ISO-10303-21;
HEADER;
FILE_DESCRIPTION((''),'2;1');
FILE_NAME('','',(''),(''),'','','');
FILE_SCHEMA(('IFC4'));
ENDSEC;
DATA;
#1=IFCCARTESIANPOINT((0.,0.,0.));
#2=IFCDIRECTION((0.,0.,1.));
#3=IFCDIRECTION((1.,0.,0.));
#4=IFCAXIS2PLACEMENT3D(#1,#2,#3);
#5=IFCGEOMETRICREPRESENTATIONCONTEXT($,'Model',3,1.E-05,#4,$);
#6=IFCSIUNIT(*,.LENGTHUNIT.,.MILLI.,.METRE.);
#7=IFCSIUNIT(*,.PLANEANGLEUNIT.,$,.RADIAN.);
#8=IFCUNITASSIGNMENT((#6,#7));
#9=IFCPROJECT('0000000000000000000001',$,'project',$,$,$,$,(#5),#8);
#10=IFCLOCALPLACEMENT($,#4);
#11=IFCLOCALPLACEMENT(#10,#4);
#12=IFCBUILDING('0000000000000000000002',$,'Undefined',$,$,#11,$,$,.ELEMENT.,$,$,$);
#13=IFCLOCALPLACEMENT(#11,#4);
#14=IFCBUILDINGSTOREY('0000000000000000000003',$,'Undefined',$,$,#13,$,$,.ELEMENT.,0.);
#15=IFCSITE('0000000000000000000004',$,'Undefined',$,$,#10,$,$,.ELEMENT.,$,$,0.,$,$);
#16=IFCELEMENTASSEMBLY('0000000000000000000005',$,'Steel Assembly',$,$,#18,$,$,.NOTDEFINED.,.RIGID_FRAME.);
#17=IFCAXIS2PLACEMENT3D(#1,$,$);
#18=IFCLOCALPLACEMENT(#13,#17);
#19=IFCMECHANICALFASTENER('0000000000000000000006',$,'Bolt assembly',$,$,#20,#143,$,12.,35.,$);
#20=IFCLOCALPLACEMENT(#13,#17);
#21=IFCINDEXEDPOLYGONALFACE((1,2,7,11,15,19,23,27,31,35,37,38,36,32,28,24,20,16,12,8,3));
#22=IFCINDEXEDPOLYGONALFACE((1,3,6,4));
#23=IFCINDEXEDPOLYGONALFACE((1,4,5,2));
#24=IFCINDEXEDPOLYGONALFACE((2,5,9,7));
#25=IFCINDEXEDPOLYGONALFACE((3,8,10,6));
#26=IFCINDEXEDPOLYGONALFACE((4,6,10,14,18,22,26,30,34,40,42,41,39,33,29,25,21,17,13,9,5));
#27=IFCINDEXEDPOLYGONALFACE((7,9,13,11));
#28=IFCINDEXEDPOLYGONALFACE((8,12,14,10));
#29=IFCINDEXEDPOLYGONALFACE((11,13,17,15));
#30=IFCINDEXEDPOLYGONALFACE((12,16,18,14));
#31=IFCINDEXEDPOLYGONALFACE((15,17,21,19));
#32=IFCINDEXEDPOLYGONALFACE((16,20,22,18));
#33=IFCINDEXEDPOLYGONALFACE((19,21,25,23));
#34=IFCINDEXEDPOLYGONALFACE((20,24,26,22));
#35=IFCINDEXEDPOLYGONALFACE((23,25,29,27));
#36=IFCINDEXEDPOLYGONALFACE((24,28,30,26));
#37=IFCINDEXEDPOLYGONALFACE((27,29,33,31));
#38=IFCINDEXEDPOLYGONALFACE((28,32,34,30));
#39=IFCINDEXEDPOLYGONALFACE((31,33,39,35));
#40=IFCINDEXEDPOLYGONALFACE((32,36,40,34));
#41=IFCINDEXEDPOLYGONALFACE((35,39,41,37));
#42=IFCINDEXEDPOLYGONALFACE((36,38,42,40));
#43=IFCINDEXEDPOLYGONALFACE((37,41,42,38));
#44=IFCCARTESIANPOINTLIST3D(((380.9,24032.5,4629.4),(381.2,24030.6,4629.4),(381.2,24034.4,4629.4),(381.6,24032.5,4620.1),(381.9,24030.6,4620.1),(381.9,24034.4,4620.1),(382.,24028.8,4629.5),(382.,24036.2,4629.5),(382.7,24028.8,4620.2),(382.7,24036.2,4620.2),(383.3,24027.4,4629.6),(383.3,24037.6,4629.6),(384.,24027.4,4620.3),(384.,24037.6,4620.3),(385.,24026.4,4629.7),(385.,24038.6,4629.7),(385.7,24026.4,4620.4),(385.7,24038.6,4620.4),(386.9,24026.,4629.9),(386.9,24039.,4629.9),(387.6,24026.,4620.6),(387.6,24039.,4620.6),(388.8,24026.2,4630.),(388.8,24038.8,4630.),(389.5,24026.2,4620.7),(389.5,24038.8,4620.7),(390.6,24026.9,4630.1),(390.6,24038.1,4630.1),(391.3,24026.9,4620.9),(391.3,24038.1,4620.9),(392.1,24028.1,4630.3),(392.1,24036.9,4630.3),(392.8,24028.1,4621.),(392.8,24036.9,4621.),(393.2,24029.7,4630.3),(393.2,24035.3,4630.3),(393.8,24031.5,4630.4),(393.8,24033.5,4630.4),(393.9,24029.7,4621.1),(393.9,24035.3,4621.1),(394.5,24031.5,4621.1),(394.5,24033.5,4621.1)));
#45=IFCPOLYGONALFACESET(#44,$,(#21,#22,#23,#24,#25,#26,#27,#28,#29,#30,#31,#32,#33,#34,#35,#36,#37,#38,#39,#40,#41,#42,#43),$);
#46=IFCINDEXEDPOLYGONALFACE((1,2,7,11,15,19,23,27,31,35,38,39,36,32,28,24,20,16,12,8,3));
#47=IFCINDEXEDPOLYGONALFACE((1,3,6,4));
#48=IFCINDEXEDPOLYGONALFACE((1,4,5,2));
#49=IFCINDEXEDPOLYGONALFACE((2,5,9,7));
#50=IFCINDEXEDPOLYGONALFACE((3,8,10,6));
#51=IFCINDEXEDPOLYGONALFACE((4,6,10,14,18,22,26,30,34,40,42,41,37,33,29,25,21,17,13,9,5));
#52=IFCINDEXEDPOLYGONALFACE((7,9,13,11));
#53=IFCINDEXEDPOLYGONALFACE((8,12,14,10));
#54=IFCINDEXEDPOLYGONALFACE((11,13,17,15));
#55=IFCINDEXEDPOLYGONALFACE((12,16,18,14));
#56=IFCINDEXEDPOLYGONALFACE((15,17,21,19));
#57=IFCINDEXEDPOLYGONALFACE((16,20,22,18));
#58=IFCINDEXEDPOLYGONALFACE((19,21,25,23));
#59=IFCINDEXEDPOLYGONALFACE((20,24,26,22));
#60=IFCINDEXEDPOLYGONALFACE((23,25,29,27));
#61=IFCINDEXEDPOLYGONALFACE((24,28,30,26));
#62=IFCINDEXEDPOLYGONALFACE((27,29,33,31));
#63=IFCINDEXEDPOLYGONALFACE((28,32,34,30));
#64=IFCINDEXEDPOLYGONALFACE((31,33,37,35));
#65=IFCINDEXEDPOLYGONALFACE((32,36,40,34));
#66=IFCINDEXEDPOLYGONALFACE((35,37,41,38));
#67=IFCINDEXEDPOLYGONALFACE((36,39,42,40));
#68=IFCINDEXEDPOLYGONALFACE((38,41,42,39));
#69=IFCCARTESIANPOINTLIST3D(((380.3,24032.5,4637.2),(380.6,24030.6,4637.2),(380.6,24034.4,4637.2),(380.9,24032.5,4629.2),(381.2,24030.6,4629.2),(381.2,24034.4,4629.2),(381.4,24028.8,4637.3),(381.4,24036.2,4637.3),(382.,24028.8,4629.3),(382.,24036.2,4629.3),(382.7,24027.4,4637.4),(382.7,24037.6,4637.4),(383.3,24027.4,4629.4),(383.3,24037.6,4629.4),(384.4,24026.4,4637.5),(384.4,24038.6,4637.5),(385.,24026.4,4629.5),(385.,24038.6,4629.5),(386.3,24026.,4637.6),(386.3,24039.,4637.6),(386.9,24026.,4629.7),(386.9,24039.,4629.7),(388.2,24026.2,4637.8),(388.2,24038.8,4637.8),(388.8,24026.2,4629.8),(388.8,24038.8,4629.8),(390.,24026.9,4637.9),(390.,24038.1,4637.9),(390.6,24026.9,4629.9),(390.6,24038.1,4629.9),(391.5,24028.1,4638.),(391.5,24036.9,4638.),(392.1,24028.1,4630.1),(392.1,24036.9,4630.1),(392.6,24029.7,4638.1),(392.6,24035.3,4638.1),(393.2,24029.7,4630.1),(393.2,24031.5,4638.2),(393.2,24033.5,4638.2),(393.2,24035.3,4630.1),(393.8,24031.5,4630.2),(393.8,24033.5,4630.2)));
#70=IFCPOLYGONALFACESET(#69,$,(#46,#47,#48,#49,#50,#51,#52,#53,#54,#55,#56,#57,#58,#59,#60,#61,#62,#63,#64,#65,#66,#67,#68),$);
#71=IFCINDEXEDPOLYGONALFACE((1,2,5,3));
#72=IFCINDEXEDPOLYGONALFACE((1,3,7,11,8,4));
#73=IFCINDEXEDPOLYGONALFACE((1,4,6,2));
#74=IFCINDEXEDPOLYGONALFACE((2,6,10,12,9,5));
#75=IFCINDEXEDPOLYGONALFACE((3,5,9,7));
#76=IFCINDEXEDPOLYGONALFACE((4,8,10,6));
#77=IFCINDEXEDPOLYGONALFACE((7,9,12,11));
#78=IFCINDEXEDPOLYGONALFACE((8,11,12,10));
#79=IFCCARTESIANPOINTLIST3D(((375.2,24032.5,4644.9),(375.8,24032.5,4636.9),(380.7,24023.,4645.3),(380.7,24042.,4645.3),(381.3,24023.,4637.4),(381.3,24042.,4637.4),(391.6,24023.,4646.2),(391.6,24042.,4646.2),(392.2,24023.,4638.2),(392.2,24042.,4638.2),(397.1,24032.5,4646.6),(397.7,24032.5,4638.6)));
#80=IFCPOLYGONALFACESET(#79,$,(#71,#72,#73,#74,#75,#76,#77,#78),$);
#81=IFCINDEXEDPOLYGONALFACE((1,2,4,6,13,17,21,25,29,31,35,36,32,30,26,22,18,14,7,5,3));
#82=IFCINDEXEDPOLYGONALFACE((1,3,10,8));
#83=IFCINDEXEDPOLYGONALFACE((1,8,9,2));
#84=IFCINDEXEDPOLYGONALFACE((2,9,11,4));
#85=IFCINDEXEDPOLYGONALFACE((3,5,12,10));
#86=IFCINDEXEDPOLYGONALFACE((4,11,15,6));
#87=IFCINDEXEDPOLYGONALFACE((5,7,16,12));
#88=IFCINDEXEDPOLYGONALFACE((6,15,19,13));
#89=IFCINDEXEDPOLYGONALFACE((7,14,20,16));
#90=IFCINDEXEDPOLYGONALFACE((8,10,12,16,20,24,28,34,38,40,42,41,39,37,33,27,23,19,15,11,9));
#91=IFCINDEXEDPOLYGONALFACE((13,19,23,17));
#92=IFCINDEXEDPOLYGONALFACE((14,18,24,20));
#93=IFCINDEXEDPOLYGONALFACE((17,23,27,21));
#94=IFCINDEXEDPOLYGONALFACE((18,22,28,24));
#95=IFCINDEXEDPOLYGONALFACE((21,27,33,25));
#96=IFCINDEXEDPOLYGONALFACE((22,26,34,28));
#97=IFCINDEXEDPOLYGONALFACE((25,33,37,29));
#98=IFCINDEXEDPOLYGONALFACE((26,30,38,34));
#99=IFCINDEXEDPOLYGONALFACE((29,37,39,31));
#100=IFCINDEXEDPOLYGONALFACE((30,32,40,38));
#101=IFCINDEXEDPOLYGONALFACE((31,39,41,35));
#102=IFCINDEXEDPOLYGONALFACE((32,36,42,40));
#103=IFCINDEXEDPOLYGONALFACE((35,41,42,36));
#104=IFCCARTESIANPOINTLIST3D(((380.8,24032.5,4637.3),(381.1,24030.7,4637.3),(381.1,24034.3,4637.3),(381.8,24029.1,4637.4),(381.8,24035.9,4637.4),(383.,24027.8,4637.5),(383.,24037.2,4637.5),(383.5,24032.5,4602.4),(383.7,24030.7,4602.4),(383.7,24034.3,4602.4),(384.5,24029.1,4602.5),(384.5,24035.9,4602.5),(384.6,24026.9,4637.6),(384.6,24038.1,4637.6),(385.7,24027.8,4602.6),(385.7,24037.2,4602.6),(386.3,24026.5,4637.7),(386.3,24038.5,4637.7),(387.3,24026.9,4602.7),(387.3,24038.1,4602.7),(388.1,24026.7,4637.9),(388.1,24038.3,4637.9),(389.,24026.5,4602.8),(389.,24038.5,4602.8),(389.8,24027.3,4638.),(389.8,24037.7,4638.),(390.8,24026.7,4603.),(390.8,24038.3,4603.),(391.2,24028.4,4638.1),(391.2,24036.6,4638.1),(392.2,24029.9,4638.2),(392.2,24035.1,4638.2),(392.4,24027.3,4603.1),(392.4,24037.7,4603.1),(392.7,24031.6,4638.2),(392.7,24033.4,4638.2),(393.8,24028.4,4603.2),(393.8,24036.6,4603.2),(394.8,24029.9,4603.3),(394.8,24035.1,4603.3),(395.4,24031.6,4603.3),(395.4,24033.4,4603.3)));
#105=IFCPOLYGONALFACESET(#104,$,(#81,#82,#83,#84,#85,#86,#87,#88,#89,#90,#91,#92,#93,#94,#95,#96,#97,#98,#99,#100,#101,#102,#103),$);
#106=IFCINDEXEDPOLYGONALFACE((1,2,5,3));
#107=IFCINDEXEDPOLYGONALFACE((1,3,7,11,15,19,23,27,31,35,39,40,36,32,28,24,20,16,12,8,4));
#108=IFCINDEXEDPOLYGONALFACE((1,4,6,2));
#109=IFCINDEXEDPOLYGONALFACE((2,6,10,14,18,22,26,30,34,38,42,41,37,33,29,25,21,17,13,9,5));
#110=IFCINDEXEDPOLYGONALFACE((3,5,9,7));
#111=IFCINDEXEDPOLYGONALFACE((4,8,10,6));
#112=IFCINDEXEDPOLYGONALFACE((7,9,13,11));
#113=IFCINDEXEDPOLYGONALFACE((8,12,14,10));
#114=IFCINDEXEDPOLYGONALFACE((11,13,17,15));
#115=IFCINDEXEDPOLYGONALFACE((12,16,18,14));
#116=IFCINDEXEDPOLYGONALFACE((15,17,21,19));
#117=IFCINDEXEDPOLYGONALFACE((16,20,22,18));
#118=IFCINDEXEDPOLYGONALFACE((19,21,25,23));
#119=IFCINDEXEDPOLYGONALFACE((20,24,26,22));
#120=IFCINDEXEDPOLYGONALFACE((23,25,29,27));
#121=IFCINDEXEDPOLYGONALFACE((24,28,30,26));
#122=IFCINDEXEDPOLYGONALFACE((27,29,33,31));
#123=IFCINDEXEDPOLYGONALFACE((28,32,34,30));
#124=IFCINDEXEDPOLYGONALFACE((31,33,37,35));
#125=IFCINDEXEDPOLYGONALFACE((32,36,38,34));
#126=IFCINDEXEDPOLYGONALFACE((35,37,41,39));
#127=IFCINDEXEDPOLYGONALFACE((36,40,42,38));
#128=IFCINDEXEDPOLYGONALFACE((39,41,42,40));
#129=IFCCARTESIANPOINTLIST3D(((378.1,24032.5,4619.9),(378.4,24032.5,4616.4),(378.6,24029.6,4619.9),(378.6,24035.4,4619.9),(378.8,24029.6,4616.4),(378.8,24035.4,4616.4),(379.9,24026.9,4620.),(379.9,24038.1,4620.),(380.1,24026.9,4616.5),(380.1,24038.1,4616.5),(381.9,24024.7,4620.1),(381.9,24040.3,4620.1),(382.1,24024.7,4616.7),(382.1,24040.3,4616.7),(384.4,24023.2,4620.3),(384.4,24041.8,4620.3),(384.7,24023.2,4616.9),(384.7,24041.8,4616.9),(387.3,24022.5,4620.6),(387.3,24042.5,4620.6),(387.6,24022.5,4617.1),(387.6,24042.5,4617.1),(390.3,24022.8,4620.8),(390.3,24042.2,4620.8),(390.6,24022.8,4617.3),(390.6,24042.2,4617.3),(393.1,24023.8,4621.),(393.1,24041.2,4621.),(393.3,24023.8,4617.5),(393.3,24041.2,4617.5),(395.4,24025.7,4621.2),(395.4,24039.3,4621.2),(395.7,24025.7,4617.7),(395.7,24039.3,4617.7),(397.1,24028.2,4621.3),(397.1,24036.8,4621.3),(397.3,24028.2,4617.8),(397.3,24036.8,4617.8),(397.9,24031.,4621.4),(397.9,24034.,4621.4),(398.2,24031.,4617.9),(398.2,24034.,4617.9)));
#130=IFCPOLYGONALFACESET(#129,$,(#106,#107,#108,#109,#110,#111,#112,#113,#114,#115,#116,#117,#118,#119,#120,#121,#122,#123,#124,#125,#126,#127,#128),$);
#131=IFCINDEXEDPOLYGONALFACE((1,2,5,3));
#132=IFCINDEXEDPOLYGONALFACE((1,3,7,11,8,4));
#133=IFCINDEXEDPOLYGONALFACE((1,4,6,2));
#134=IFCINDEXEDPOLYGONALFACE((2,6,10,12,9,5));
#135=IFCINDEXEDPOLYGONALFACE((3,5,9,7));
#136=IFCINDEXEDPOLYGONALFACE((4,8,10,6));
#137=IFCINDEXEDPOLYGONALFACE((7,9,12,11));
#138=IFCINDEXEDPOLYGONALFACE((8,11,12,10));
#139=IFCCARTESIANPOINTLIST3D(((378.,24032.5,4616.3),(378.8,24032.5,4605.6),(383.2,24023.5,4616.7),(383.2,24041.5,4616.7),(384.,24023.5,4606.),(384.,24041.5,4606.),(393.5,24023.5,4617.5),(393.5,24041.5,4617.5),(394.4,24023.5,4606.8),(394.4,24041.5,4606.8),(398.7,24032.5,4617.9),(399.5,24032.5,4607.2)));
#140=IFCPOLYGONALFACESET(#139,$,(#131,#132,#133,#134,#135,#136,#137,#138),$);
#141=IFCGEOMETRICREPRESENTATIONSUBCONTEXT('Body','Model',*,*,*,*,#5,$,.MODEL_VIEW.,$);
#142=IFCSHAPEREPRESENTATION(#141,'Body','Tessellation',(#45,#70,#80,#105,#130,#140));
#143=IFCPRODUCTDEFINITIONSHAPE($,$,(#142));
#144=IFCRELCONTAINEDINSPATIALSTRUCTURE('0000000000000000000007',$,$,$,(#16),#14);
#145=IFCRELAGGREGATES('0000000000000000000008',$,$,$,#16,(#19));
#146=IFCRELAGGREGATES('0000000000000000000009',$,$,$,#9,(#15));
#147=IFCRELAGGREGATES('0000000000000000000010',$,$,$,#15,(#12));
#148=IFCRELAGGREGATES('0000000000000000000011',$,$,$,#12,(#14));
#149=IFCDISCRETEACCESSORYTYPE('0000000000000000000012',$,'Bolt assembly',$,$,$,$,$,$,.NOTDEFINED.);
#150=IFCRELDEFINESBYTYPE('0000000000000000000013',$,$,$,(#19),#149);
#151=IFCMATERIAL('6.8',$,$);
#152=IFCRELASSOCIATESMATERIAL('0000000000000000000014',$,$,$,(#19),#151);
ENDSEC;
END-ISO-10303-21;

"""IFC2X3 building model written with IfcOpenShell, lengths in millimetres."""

from ifc_helpers import new_model, si_unit, frame, origin_with_axes, origin_2d_with_axis, place, context, subcontext, project, spatial, polyline, circle, outline, extrude, source, transform, mapped, material, type_object, element, aggregate, save


model = new_model("IFC2X3")

# Units and contexts
model_context = context("Model", 3, precision=1e-05, world=origin_with_axes())
body_context = subcontext(model_context, "Body", "Model", "MODEL_VIEW")
ifc_project = project(units=[si_unit("LENGTHUNIT", "METRE", prefix="MILLI"), si_unit("PLANEANGLEUNIT", "RADIAN")], contexts=[model_context])

# Site, building, storey
site_placement = place(None, origin_with_axes())
site = spatial("IfcSite", under=ifc_project, at=site_placement, Name="Undefined", CompositionType="ELEMENT", RefElevation=0.0)
building_placement = place(site_placement, origin_with_axes())
building = spatial("IfcBuilding", under=site, at=building_placement, Name="Undefined", CompositionType="ELEMENT")
storey_placement = place(building_placement, origin_with_axes())
storey = spatial("IfcBuildingStorey", under=building, at=storey_placement, Name="Undefined", CompositionType="ELEMENT", Elevation=0.0)

# Shared definitions
ifc_material_1 = material(Name="6.8")
discrete_accessory_type_1 = type_object("IfcDiscreteAccessoryType", Name="Bolt assembly")

# Element assembly, mechanical fastener
shared_shape_1 = source(origin_with_axes(), body_context, "Body", "SweptSolid", [
    extrude(circle(Radius=6.5, at=origin_2d_with_axis()), frame((0.0, -0.1, 0.0), z_axis=(0.0, 1.0, 0.0), x_axis=(1.0, 0.0, 0.0)), (0.0, 0.0, 1.0), 9.3),
    extrude(circle(Radius=6.5, at=origin_2d_with_axis()), frame((0.0, -7.9, 0.0), z_axis=(0.0, 1.0, 0.0), x_axis=(1.0, 0.0, 0.0)), (0.0, 0.0, 1.0), 8.0),
    extrude(outline(polyline([(11.0, 0.0), (5.5, 9.5), (-5.5, 9.5), (-11.0, 0.0), (-5.5, -9.5), (5.5, -9.5), (11.0, 0.0)])), frame((0.0, -16.0, 0.0), z_axis=(0.0, 1.0, 0.0), x_axis=(1.0, 0.0, 0.0)), (0.0, 0.0, 1.0), 8.0),
    extrude(circle(Radius=6.0, at=origin_2d_with_axis()), frame((0.0, -8.0, 0.0), z_axis=(0.0, 1.0, 0.0), x_axis=(1.0, 0.0, 0.0)), (0.0, 0.0, 1.0), 35.0),
    extrude(circle(Radius=10.0, at=origin_2d_with_axis()), frame((0.0, 9.2, 0.0), z_axis=(0.0, 1.0, 0.0), x_axis=(1.0, 0.0, 0.0)), (0.0, 0.0, 1.0), 3.5),
    extrude(outline(polyline([(10.4, 0.0), (5.2, 9.0), (-5.2, 9.0), (-10.4, 0.0), (-5.2, -9.0), (5.2, -9.0), (10.4, 0.0)])), frame((0.0, 12.7, 0.0), z_axis=(0.0, 1.0, 0.0), x_axis=(1.0, 0.0, 0.0)), (0.0, 0.0, 1.0), 10.8),
])
assembly_1_placement = place(storey_placement, origin_with_axes())
assembly_1 = element("IfcElementAssembly", 1, at=assembly_1_placement, inside=storey, Name="Steel Assembly", AssemblyPlace="NOTDEFINED", PredefinedType="RIGID_FRAME")
mechanical_fastener_1_placement = place(assembly_1_placement, frame((387.4, 24032.5, 4629.8), z_axis=(0.0, -1.0, 0.0), x_axis=(-0.997054, 0.0, -0.076696)))
mechanical_fastener_1 = element("IfcMechanicalFastener", 2, at=mechanical_fastener_1_placement, type_object=discrete_accessory_type_1, material=ifc_material_1, Name="Bolt assembly", NominalDiameter=12.0, NominalLength=35.0, context=body_context, shape_type="MappedRepresentation", body=[
    mapped(shared_shape_1, transform((0.0, 0.0, 0.0))),
])
aggregate(assembly_1, [mechanical_fastener_1])

save(model, "model.ifc")
